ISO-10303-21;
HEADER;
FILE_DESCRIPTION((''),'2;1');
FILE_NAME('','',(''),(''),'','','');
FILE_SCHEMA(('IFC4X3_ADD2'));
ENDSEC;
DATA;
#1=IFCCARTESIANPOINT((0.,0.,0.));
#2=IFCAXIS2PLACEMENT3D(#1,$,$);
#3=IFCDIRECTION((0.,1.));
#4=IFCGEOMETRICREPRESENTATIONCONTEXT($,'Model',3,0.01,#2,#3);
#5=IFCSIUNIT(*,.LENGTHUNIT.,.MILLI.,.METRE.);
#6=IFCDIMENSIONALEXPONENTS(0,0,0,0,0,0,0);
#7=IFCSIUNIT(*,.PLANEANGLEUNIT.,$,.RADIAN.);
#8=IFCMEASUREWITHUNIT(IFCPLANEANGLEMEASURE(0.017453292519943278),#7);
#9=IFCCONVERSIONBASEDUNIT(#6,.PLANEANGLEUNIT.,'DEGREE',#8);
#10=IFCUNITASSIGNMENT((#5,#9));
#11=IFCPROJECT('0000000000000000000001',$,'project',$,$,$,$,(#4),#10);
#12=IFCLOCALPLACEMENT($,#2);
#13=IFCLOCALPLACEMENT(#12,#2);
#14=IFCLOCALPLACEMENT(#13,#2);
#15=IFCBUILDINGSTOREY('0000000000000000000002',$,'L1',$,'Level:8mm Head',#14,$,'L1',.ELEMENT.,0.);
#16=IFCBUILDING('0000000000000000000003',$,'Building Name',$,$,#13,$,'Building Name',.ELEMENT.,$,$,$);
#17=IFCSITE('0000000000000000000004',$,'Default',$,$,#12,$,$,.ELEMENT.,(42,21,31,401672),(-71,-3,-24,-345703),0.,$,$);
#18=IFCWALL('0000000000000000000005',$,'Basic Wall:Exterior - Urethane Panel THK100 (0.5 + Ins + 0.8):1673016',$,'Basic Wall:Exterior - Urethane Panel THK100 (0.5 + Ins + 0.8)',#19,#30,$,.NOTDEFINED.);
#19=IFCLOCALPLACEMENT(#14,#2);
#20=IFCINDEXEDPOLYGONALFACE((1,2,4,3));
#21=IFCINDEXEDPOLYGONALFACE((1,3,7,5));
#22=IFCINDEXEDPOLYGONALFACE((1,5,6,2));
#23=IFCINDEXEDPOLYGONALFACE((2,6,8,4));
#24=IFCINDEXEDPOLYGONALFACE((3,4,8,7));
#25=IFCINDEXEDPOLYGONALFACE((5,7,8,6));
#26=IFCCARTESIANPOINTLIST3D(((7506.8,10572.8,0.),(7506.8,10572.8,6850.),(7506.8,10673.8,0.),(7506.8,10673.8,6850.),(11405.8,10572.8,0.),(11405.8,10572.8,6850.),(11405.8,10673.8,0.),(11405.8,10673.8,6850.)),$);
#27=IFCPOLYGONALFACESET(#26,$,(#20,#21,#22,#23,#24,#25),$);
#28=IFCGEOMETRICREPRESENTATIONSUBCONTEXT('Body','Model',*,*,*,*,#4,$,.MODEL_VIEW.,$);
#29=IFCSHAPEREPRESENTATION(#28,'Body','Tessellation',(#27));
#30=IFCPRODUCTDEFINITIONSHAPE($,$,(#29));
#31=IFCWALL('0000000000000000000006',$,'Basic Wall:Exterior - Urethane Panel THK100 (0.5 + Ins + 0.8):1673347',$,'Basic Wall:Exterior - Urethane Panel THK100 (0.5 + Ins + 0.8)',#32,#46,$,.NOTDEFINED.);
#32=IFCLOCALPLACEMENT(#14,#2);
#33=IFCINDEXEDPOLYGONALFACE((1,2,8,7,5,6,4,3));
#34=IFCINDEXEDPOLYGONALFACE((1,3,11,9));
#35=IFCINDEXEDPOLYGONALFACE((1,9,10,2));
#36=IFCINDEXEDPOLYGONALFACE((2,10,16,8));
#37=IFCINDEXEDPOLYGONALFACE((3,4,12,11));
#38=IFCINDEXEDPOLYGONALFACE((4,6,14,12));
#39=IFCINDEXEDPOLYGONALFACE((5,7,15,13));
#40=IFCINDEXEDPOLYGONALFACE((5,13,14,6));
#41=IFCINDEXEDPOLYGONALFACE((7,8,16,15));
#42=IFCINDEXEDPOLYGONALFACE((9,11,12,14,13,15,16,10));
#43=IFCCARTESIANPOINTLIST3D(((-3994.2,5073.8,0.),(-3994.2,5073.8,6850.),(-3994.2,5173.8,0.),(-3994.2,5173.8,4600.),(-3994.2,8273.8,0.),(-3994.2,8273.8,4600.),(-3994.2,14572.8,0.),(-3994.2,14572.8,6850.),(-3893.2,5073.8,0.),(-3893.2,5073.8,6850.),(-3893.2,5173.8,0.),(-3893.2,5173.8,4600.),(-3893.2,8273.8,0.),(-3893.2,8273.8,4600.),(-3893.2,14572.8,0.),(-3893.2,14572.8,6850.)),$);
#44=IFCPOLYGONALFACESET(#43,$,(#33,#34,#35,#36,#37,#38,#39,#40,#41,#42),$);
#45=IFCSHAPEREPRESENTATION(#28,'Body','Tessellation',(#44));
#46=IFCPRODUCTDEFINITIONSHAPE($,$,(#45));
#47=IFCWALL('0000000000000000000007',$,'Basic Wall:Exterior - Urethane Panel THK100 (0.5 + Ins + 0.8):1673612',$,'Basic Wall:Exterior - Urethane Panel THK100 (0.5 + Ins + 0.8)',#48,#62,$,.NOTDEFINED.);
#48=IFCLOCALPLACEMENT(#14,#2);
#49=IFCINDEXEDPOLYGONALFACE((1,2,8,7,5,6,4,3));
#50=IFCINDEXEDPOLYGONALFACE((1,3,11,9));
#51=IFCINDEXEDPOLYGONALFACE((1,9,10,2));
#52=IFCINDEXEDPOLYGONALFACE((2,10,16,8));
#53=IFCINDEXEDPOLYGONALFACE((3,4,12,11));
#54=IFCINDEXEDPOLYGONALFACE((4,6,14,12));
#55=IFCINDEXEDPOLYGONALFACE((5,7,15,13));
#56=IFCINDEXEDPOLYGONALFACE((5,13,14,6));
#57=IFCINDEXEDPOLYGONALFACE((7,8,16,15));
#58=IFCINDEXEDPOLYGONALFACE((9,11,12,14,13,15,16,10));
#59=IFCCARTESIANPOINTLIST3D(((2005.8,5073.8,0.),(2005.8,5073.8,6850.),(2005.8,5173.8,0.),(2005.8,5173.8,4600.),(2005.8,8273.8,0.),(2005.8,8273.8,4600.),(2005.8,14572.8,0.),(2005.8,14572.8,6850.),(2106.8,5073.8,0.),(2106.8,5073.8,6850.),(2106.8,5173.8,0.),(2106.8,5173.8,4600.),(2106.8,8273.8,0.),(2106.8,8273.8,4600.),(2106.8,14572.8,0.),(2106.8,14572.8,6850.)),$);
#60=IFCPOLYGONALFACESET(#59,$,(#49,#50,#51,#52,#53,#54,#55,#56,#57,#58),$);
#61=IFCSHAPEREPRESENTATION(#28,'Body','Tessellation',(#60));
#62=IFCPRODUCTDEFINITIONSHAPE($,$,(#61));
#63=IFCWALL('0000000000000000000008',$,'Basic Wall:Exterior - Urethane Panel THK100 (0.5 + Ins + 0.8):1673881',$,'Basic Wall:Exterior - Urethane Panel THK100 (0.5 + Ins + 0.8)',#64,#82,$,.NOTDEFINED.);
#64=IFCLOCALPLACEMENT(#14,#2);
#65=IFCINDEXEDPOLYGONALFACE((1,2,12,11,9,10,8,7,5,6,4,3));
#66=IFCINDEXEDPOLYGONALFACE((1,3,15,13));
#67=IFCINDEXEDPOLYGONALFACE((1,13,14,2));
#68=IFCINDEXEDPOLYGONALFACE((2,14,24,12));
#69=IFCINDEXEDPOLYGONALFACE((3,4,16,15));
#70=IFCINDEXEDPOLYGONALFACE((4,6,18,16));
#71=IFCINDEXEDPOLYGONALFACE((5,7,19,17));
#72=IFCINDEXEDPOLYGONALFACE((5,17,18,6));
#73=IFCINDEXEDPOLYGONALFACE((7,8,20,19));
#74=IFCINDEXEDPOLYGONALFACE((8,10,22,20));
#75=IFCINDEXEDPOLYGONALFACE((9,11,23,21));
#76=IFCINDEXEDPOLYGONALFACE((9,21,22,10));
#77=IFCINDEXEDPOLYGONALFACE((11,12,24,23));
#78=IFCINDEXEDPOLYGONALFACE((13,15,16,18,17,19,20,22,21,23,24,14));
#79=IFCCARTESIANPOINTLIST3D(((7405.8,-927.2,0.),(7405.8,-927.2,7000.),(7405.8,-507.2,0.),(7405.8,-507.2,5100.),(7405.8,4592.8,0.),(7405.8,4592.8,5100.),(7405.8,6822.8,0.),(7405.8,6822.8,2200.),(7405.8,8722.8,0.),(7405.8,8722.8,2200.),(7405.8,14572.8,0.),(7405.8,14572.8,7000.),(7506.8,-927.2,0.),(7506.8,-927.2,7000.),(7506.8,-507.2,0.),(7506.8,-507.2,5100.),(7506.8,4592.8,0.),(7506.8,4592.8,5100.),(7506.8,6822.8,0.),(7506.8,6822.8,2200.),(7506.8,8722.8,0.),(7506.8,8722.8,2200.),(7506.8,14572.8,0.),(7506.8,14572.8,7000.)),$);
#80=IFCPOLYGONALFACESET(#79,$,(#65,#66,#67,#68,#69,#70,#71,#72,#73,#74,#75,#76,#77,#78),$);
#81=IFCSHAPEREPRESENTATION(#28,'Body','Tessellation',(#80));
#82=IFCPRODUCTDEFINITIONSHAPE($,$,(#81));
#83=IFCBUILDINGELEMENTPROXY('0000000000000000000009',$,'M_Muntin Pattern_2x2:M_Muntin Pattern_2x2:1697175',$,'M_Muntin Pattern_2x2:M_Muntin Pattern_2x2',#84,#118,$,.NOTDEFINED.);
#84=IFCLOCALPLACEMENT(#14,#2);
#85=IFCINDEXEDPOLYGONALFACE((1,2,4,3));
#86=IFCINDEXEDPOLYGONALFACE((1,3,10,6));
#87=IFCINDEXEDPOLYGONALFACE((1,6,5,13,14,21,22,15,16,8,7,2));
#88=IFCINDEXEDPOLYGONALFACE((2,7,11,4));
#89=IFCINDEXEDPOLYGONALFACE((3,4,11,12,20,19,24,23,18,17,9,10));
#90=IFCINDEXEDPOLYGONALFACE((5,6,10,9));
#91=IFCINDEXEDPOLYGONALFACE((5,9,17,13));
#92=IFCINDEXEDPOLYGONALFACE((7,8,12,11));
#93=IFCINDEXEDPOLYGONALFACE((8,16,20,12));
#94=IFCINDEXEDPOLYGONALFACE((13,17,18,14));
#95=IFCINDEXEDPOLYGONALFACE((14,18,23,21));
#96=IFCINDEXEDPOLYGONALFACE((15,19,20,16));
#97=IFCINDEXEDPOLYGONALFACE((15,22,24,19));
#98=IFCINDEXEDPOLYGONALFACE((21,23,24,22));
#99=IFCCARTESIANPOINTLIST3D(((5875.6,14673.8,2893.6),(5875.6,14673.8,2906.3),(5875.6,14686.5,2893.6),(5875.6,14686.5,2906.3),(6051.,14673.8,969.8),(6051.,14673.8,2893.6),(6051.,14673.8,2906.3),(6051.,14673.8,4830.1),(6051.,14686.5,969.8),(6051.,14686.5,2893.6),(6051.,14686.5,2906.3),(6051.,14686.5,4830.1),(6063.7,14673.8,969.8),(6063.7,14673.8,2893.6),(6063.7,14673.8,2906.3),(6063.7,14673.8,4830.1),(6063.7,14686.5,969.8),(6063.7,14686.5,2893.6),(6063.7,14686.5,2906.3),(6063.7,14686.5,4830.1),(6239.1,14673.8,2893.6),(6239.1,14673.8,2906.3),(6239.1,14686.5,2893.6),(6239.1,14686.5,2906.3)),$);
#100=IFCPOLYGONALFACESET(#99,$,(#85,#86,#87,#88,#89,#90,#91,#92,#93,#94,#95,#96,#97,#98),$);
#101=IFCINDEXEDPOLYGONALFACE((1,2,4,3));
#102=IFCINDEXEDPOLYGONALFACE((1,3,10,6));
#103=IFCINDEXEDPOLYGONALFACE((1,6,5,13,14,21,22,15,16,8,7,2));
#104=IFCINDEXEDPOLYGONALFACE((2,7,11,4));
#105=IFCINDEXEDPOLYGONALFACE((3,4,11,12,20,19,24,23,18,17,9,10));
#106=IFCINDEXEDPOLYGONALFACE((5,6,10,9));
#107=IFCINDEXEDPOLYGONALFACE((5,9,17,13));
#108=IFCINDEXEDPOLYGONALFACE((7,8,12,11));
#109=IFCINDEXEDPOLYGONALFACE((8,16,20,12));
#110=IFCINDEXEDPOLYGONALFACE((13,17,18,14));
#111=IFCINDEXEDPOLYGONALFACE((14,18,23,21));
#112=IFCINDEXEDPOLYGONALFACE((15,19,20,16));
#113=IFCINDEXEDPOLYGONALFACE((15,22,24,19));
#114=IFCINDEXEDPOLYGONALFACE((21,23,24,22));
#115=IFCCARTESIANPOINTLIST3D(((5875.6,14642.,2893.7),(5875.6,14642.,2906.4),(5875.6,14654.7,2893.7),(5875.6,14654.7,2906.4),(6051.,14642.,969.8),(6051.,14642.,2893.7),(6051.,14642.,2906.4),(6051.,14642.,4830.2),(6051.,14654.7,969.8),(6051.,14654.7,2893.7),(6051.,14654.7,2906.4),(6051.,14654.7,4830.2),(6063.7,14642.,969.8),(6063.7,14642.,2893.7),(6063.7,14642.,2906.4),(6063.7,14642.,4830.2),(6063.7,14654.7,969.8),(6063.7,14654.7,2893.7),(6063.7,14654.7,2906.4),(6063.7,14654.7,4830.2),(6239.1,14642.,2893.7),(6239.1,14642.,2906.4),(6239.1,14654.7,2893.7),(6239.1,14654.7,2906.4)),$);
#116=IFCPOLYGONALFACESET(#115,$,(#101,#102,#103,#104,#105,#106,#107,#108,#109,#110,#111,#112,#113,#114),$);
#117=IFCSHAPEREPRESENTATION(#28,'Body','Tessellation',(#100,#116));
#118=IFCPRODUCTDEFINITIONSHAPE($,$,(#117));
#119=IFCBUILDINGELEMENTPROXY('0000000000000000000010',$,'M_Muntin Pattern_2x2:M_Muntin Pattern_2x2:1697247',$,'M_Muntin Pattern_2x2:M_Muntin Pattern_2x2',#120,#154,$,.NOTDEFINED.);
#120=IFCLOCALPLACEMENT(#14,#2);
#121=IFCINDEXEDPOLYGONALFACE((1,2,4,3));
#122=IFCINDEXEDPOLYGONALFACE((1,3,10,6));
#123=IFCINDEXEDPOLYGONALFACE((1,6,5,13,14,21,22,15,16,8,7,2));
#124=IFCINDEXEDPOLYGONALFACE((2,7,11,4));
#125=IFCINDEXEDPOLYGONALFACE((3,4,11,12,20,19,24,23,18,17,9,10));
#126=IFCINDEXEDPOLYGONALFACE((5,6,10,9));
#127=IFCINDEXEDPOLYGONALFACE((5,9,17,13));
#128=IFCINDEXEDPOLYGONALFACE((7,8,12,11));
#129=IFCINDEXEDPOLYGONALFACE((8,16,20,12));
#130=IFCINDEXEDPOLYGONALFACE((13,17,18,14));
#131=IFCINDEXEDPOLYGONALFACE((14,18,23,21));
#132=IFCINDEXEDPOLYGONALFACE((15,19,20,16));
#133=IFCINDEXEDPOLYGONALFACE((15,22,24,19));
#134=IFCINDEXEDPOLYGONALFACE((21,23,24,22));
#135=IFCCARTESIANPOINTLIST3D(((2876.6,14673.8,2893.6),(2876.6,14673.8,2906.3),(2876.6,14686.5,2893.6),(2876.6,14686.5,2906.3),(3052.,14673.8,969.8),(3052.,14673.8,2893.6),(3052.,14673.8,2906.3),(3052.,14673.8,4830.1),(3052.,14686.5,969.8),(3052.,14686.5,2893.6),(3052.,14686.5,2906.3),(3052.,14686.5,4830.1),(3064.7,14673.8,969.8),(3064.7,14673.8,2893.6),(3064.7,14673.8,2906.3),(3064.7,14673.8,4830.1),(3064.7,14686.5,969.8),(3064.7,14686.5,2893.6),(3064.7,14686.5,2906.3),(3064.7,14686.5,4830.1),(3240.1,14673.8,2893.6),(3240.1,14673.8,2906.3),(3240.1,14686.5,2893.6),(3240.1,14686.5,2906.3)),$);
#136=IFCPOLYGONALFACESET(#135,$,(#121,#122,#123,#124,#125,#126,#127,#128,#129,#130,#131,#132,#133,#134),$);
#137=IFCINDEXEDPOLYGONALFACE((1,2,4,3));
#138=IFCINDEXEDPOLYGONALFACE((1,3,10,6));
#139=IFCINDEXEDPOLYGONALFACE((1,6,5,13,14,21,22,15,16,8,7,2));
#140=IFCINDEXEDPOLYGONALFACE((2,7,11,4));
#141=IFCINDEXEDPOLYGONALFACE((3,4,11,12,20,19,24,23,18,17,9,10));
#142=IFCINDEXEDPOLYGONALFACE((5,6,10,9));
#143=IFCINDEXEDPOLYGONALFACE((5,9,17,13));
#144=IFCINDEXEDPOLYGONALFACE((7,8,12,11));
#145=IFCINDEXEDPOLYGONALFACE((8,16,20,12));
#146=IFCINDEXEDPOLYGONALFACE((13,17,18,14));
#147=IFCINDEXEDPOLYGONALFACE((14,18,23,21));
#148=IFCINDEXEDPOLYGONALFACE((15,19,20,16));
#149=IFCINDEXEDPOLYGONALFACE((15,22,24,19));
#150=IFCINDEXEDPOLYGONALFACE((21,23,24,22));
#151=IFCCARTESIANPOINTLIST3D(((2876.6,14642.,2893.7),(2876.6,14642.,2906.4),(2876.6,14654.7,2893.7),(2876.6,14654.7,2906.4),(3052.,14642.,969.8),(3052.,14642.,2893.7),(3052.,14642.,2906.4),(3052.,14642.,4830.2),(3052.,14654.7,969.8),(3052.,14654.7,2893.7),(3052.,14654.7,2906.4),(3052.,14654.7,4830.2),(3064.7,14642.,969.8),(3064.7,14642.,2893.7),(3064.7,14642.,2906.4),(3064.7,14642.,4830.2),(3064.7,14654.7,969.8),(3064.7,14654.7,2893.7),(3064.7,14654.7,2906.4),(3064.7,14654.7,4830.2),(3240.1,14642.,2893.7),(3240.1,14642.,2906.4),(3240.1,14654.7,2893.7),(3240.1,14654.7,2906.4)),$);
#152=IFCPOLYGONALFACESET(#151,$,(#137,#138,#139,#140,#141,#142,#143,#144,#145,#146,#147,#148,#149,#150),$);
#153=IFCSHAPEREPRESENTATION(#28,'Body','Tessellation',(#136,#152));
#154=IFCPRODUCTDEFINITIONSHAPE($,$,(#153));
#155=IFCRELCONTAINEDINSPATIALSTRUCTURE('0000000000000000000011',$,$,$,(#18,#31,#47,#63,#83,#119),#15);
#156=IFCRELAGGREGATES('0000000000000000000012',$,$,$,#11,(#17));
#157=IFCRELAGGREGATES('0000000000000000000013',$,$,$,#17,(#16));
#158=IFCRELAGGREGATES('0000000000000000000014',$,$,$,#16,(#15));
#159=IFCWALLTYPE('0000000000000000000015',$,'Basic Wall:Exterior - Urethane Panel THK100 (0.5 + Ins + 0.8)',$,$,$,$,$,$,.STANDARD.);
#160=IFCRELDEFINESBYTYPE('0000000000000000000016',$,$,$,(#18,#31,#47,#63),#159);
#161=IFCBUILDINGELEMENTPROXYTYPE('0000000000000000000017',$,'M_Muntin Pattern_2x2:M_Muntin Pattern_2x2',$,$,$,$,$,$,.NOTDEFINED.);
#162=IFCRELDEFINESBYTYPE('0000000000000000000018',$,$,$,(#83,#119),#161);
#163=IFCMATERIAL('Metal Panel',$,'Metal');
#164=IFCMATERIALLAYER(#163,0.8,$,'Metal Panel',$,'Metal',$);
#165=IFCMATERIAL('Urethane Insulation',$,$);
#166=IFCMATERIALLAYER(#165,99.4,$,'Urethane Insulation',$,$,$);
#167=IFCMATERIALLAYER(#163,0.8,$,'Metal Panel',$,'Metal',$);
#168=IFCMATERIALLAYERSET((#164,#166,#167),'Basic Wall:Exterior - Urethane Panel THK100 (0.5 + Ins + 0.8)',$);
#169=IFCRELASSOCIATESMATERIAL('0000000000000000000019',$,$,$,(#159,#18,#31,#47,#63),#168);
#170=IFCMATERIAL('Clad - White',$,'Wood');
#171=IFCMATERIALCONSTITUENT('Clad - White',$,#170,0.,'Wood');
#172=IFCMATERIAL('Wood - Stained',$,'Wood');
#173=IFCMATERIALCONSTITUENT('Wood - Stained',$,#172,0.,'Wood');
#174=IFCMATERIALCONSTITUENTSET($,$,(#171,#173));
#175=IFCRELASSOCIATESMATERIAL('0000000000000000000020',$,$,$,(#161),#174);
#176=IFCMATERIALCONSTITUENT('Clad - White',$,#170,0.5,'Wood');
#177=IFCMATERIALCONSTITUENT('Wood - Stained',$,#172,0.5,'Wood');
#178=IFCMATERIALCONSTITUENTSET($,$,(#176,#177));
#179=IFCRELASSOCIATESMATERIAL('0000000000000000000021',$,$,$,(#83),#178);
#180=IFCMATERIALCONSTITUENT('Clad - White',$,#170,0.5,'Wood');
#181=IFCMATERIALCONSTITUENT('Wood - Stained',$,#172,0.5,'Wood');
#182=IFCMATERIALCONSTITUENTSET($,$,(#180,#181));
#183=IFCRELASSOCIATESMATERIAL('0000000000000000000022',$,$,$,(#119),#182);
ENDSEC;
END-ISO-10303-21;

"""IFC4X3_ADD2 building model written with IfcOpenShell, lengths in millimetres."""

from ifc_helpers import new_model, entity, si_unit, converted_unit, direction, frame, frame_2d, origin, place, context, subcontext, project, spatial, polyline, rectangle, outline, extrude, clip, bounded_halfspace, source, transform, mapped, material, layer, layer_set, constituent, constituent_set, type_object, type_shapes, element, save


model = new_model("IFC4X3_ADD2")

# Units and contexts
model_context = context("Model", 3, precision=0.01, world=origin(), true_north=direction((0.0, 1.0)))
body_context = subcontext(model_context, "Body", "Model", "MODEL_VIEW")
ifc_project = project(units=[si_unit("LENGTHUNIT", "METRE", prefix="MILLI"), converted_unit("PLANEANGLEUNIT", "DEGREE", entity("IfcPlaneAngleMeasure", 0.017453292519943278), si_unit("PLANEANGLEUNIT", "RADIAN"), dimensions=[0, 0, 0, 0, 0, 0, 0])], contexts=[model_context])

# Site, building, storey
site_placement = place(None, origin())
site = spatial("IfcSite", under=ifc_project, at=site_placement, Name="Default", CompositionType="ELEMENT", RefLatitude=(42, 21, 31, 401672), RefLongitude=(-71, -3, -24, -345703), RefElevation=0.0)
building_placement = place(site_placement, origin())
building = spatial("IfcBuilding", under=site, at=building_placement, Name="Building Name", LongName="Building Name", CompositionType="ELEMENT")
storey_placement = place(building_placement, origin())
storey = spatial("IfcBuildingStorey", under=building, at=storey_placement, Name="L1", ObjectType="Level:8mm Head", LongName="L1", CompositionType="ELEMENT", Elevation=0.0)

# Wall
ifc_material_1 = material(Name="Metal Panel", Category="Metal")
ifc_layer_1 = layer(ifc_material_1, 0.8, Name="Metal Panel", Category="Metal")
ifc_material_2 = material(Name="Urethane Insulation")
ifc_layer_2 = layer(ifc_material_2, 99.4, Name="Urethane Insulation")
ifc_layer_3 = layer(ifc_material_1, 0.8, Name="Metal Panel", Category="Metal")
ifc_layer_set_1 = layer_set([ifc_layer_1, ifc_layer_2, ifc_layer_3], Name="Basic Wall:Exterior - Urethane Panel THK100 (0.5 + Ins + 0.8)")
wall_type = type_object("IfcWallType", Name="Basic Wall:Exterior - Urethane Panel THK100 (0.5 + Ins + 0.8)", PredefinedType="STANDARD", material=ifc_layer_set_1)
wall_1_placement = place(storey_placement, frame((7506.8, 10623.3, 0.0)))
element("IfcWall", 1, at=wall_1_placement, inside=storey, type_object=wall_type, material=ifc_layer_set_1, Name="Basic Wall:Exterior - Urethane Panel THK100 (0.5 + Ins + 0.8):1673016", ObjectType="Basic Wall:Exterior - Urethane Panel THK100 (0.5 + Ins + 0.8)", PredefinedType="NOTDEFINED", context=body_context, shape_type="Clipping", body=[
    clip(extrude(rectangle(XDim=3899.0, YDim=101.0, at=frame_2d((1949.5, 0.0), x_axis=(-1.0, 0.0))), origin(), (0.0, 0.0, 1.0), 6850.0), bounded_halfspace(frame((0.0, -50.5, 6850.0), z_axis=(0.0, 0.0, -1.0), x_axis=(1.0, 0.0, 0.0)), True, frame((0.0, -50.5, 6850.0)), polyline([(0.0, 0.0), (3899.0, 0.0), (3899.0, 101.0), (0.0, 101.0), (0.0, 0.0)]))),
])

# Walls, openings
wall_2_placement = place(storey_placement, frame((-3943.7, 14572.8, 0.0), z_axis=(0.0, 0.0, 1.0), x_axis=(0.0, -1.0, 0.0)))
wall_2 = element("IfcWall", 2, at=wall_2_placement, inside=storey, type_object=wall_type, material=ifc_layer_set_1, Name="Basic Wall:Exterior - Urethane Panel THK100 (0.5 + Ins + 0.8):1673347", ObjectType="Basic Wall:Exterior - Urethane Panel THK100 (0.5 + Ins + 0.8)", PredefinedType="NOTDEFINED", context=body_context, shape_type="Clipping", body=[
    clip(extrude(rectangle(XDim=9499.0, YDim=101.0, at=frame_2d((4749.5, 0.0), x_axis=(1.0, 0.0))), origin(), (0.0, 0.0, 1.0), 6850.0), bounded_halfspace(frame((0.0, -50.5, 6850.0), z_axis=(0.0, 0.0, -1.0), x_axis=(0.0, 1.0, 0.0)), True, frame((0.0, -50.5, 6850.0)), polyline([(0.0, 0.0), (9499.0, 0.0), (9499.0, 101.0), (0.0, 101.0), (0.0, 0.0)]))),
])
opening_1_placement = place(wall_2_placement, frame((6299.0, -50.5, 0.0)))
element("IfcOpeningElement", 3, at=opening_1_placement, cuts=wall_2, PredefinedType="OPENING", context=body_context, shape_type="SweptSolid", body=[
    extrude(rectangle(XDim=4600.0, YDim=3100.0, at=frame_2d((2300.0, 1550.0), x_axis=(1.0, 0.0))), frame((0.0, 0.0, 0.0), z_axis=(0.0, 1.0, 0.0), x_axis=(0.0, 0.0, 1.0)), (0.0, 0.0, 1.0), 101.0),
])
wall_3_placement = place(storey_placement, frame((2056.3, 14572.8, 0.0), z_axis=(0.0, 0.0, 1.0), x_axis=(0.0, -1.0, 0.0)))
wall_3 = element("IfcWall", 4, at=wall_3_placement, inside=storey, type_object=wall_type, material=ifc_layer_set_1, Name="Basic Wall:Exterior - Urethane Panel THK100 (0.5 + Ins + 0.8):1673612", ObjectType="Basic Wall:Exterior - Urethane Panel THK100 (0.5 + Ins + 0.8)", PredefinedType="NOTDEFINED", context=body_context, shape_type="Clipping", body=[
    clip(extrude(rectangle(XDim=101.0, YDim=9499.0, at=frame_2d((4749.5, 0.0), x_axis=(0.0, 1.0))), origin(), (0.0, 0.0, 1.0), 6850.0), bounded_halfspace(frame((9499.0, -50.5, 6850.0), z_axis=(0.0, 0.0, -1.0), x_axis=(0.0, 1.0, 0.0)), True, frame((9499.0, -50.5, 6850.0)), polyline([(0.0, 0.0), (0.0, 101.0), (-9499.0, 101.0), (-9499.0, 0.0), (0.0, 0.0)]))),
])
opening_2_placement = place(wall_3_placement, frame((6299.0, -50.5, 0.0)))
element("IfcOpeningElement", 5, at=opening_2_placement, cuts=wall_3, PredefinedType="OPENING", context=body_context, shape_type="SweptSolid", body=[
    extrude(rectangle(XDim=4600.0, YDim=3100.0, at=frame_2d((2300.0, 1550.0), x_axis=(1.0, 0.0))), frame((0.0, 0.0, 0.0), z_axis=(0.0, 1.0, 0.0), x_axis=(0.0, 0.0, 1.0)), (0.0, 0.0, 1.0), 101.0),
])

# Wall, openings
wall_4_placement = place(storey_placement, frame((7456.3, 14572.8, 0.0), z_axis=(0.0, 0.0, 1.0), x_axis=(0.0, -1.0, 0.0)))
wall_4 = element("IfcWall", 6, at=wall_4_placement, inside=storey, type_object=wall_type, material=ifc_layer_set_1, Name="Basic Wall:Exterior - Urethane Panel THK100 (0.5 + Ins + 0.8):1673881", ObjectType="Basic Wall:Exterior - Urethane Panel THK100 (0.5 + Ins + 0.8)", PredefinedType="NOTDEFINED", context=body_context, shape_type="SweptSolid", body=[
    extrude(rectangle(XDim=15500.0, YDim=101.0, at=frame_2d((7750.0, 0.0), x_axis=(-1.0, 0.0))), origin(), (0.0, 0.0, 1.0), 7000.0),
])
opening_3_placement = place(wall_4_placement, frame((5850.0, -50.5, 0.0)))
element("IfcOpeningElement", 7, at=opening_3_placement, cuts=wall_4, PredefinedType="OPENING", context=body_context, shape_type="SweptSolid", body=[
    extrude(rectangle(XDim=2200.0, YDim=1900.0, at=frame_2d((1100.0, 950.0), x_axis=(1.0, 0.0))), frame((0.0, 0.0, 0.0), z_axis=(0.0, 1.0, 0.0), x_axis=(0.0, 0.0, 1.0)), (0.0, 0.0, 1.0), 101.0),
])
opening_4_placement = place(wall_4_placement, frame((9980.0, -50.5, 0.0)))
element("IfcOpeningElement", 8, at=opening_4_placement, cuts=wall_4, PredefinedType="OPENING", context=body_context, shape_type="SweptSolid", body=[
    extrude(rectangle(XDim=5100.0, YDim=5100.0, at=frame_2d((2550.0, 2550.0), x_axis=(1.0, 0.0))), frame((0.0, 0.0, 0.0), z_axis=(0.0, 1.0, 0.0), x_axis=(0.0, 0.0, 1.0)), (0.0, 0.0, 1.0), 101.0),
])

# Building element proxies
ifc_material_3 = material(Name="Clad - White", Category="Wood")
ifc_constituent_1 = constituent(ifc_material_3, Name="Clad - White", Category="Wood", fraction=0.5)
ifc_material_4 = material(Name="Wood - Stained", Category="Wood")
ifc_constituent_2 = constituent(ifc_material_4, Name="Wood - Stained", Category="Wood", fraction=0.5)
ifc_constituent_set_1 = constituent_set(constituents=[ifc_constituent_1, ifc_constituent_2])
ifc_constituent_3 = constituent(ifc_material_3, Name="Clad - White", Category="Wood", fraction=0.0)
ifc_constituent_4 = constituent(ifc_material_4, Name="Wood - Stained", Category="Wood", fraction=0.0)
ifc_constituent_set_2 = constituent_set(constituents=[ifc_constituent_3, ifc_constituent_4])
building_element_proxy_type_1 = type_object("IfcBuildingElementProxyType", Name="M_Muntin Pattern_2x2:M_Muntin Pattern_2x2", PredefinedType="NOTDEFINED", material=ifc_constituent_set_2)
shared_shape_1 = source(origin(), body_context, "Body", "SweptSolid", [
    extrude(outline(polyline([(6.4, -6.4), (1930.1, -6.4), (1930.1, 6.3), (6.4, 6.3), (6.4, 181.7), (-6.3, 181.7), (-6.3, 6.3), (-1930.2, 6.3), (-1930.2, -6.4), (-6.3, -6.4), (-6.3, -181.7), (6.4, -181.7), (6.4, -6.4)])), frame((0.0, 9.5, 1930.1), z_axis=(0.0, 1.0, 0.0), x_axis=(0.0, 0.0, 1.0)), (0.0, 0.0, 1.0), 12.7),
    extrude(outline(polyline([(6.4, -6.4), (1930.2, -6.4), (1930.2, 6.3), (6.4, 6.3), (6.4, 181.7), (-6.3, 181.7), (-6.3, 6.3), (-1930.2, 6.3), (-1930.2, -6.4), (-6.3, -6.4), (-6.3, -181.7), (6.4, -181.7), (6.4, -6.4)])), frame((0.0, -22.2, 1930.2), z_axis=(0.0, 1.0, 0.0), x_axis=(0.0, 0.0, 1.0)), (0.0, 0.0, 1.0), 12.7),
])
type_shapes(building_element_proxy_type_1, [shared_shape_1])
proxy_1_placement = place(storey_placement, frame((6057.4, 14664.3, 969.8)))
element("IfcBuildingElementProxy", 9, at=proxy_1_placement, inside=storey, type_object=building_element_proxy_type_1, material=ifc_constituent_set_1, Name="M_Muntin Pattern_2x2:M_Muntin Pattern_2x2:1697175", ObjectType="M_Muntin Pattern_2x2:M_Muntin Pattern_2x2", PredefinedType="NOTDEFINED", context=body_context, shape_type="MappedRepresentation", body=[
    mapped(shared_shape_1, transform((0.0, 0.0, 0.0), scale=1.0)),
])
ifc_constituent_5 = constituent(ifc_material_3, Name="Clad - White", Category="Wood", fraction=0.5)
ifc_constituent_6 = constituent(ifc_material_4, Name="Wood - Stained", Category="Wood", fraction=0.5)
ifc_constituent_set_3 = constituent_set(constituents=[ifc_constituent_5, ifc_constituent_6])
proxy_2_placement = place(storey_placement, frame((3058.4, 14664.3, 969.8)))
element("IfcBuildingElementProxy", 10, at=proxy_2_placement, inside=storey, type_object=building_element_proxy_type_1, material=ifc_constituent_set_3, Name="M_Muntin Pattern_2x2:M_Muntin Pattern_2x2:1697247", ObjectType="M_Muntin Pattern_2x2:M_Muntin Pattern_2x2", PredefinedType="NOTDEFINED", context=body_context, shape_type="MappedRepresentation", body=[
    mapped(shared_shape_1, transform((0.0, 0.0, 0.0), scale=1.0)),
])

save(model, "model.ifc")
